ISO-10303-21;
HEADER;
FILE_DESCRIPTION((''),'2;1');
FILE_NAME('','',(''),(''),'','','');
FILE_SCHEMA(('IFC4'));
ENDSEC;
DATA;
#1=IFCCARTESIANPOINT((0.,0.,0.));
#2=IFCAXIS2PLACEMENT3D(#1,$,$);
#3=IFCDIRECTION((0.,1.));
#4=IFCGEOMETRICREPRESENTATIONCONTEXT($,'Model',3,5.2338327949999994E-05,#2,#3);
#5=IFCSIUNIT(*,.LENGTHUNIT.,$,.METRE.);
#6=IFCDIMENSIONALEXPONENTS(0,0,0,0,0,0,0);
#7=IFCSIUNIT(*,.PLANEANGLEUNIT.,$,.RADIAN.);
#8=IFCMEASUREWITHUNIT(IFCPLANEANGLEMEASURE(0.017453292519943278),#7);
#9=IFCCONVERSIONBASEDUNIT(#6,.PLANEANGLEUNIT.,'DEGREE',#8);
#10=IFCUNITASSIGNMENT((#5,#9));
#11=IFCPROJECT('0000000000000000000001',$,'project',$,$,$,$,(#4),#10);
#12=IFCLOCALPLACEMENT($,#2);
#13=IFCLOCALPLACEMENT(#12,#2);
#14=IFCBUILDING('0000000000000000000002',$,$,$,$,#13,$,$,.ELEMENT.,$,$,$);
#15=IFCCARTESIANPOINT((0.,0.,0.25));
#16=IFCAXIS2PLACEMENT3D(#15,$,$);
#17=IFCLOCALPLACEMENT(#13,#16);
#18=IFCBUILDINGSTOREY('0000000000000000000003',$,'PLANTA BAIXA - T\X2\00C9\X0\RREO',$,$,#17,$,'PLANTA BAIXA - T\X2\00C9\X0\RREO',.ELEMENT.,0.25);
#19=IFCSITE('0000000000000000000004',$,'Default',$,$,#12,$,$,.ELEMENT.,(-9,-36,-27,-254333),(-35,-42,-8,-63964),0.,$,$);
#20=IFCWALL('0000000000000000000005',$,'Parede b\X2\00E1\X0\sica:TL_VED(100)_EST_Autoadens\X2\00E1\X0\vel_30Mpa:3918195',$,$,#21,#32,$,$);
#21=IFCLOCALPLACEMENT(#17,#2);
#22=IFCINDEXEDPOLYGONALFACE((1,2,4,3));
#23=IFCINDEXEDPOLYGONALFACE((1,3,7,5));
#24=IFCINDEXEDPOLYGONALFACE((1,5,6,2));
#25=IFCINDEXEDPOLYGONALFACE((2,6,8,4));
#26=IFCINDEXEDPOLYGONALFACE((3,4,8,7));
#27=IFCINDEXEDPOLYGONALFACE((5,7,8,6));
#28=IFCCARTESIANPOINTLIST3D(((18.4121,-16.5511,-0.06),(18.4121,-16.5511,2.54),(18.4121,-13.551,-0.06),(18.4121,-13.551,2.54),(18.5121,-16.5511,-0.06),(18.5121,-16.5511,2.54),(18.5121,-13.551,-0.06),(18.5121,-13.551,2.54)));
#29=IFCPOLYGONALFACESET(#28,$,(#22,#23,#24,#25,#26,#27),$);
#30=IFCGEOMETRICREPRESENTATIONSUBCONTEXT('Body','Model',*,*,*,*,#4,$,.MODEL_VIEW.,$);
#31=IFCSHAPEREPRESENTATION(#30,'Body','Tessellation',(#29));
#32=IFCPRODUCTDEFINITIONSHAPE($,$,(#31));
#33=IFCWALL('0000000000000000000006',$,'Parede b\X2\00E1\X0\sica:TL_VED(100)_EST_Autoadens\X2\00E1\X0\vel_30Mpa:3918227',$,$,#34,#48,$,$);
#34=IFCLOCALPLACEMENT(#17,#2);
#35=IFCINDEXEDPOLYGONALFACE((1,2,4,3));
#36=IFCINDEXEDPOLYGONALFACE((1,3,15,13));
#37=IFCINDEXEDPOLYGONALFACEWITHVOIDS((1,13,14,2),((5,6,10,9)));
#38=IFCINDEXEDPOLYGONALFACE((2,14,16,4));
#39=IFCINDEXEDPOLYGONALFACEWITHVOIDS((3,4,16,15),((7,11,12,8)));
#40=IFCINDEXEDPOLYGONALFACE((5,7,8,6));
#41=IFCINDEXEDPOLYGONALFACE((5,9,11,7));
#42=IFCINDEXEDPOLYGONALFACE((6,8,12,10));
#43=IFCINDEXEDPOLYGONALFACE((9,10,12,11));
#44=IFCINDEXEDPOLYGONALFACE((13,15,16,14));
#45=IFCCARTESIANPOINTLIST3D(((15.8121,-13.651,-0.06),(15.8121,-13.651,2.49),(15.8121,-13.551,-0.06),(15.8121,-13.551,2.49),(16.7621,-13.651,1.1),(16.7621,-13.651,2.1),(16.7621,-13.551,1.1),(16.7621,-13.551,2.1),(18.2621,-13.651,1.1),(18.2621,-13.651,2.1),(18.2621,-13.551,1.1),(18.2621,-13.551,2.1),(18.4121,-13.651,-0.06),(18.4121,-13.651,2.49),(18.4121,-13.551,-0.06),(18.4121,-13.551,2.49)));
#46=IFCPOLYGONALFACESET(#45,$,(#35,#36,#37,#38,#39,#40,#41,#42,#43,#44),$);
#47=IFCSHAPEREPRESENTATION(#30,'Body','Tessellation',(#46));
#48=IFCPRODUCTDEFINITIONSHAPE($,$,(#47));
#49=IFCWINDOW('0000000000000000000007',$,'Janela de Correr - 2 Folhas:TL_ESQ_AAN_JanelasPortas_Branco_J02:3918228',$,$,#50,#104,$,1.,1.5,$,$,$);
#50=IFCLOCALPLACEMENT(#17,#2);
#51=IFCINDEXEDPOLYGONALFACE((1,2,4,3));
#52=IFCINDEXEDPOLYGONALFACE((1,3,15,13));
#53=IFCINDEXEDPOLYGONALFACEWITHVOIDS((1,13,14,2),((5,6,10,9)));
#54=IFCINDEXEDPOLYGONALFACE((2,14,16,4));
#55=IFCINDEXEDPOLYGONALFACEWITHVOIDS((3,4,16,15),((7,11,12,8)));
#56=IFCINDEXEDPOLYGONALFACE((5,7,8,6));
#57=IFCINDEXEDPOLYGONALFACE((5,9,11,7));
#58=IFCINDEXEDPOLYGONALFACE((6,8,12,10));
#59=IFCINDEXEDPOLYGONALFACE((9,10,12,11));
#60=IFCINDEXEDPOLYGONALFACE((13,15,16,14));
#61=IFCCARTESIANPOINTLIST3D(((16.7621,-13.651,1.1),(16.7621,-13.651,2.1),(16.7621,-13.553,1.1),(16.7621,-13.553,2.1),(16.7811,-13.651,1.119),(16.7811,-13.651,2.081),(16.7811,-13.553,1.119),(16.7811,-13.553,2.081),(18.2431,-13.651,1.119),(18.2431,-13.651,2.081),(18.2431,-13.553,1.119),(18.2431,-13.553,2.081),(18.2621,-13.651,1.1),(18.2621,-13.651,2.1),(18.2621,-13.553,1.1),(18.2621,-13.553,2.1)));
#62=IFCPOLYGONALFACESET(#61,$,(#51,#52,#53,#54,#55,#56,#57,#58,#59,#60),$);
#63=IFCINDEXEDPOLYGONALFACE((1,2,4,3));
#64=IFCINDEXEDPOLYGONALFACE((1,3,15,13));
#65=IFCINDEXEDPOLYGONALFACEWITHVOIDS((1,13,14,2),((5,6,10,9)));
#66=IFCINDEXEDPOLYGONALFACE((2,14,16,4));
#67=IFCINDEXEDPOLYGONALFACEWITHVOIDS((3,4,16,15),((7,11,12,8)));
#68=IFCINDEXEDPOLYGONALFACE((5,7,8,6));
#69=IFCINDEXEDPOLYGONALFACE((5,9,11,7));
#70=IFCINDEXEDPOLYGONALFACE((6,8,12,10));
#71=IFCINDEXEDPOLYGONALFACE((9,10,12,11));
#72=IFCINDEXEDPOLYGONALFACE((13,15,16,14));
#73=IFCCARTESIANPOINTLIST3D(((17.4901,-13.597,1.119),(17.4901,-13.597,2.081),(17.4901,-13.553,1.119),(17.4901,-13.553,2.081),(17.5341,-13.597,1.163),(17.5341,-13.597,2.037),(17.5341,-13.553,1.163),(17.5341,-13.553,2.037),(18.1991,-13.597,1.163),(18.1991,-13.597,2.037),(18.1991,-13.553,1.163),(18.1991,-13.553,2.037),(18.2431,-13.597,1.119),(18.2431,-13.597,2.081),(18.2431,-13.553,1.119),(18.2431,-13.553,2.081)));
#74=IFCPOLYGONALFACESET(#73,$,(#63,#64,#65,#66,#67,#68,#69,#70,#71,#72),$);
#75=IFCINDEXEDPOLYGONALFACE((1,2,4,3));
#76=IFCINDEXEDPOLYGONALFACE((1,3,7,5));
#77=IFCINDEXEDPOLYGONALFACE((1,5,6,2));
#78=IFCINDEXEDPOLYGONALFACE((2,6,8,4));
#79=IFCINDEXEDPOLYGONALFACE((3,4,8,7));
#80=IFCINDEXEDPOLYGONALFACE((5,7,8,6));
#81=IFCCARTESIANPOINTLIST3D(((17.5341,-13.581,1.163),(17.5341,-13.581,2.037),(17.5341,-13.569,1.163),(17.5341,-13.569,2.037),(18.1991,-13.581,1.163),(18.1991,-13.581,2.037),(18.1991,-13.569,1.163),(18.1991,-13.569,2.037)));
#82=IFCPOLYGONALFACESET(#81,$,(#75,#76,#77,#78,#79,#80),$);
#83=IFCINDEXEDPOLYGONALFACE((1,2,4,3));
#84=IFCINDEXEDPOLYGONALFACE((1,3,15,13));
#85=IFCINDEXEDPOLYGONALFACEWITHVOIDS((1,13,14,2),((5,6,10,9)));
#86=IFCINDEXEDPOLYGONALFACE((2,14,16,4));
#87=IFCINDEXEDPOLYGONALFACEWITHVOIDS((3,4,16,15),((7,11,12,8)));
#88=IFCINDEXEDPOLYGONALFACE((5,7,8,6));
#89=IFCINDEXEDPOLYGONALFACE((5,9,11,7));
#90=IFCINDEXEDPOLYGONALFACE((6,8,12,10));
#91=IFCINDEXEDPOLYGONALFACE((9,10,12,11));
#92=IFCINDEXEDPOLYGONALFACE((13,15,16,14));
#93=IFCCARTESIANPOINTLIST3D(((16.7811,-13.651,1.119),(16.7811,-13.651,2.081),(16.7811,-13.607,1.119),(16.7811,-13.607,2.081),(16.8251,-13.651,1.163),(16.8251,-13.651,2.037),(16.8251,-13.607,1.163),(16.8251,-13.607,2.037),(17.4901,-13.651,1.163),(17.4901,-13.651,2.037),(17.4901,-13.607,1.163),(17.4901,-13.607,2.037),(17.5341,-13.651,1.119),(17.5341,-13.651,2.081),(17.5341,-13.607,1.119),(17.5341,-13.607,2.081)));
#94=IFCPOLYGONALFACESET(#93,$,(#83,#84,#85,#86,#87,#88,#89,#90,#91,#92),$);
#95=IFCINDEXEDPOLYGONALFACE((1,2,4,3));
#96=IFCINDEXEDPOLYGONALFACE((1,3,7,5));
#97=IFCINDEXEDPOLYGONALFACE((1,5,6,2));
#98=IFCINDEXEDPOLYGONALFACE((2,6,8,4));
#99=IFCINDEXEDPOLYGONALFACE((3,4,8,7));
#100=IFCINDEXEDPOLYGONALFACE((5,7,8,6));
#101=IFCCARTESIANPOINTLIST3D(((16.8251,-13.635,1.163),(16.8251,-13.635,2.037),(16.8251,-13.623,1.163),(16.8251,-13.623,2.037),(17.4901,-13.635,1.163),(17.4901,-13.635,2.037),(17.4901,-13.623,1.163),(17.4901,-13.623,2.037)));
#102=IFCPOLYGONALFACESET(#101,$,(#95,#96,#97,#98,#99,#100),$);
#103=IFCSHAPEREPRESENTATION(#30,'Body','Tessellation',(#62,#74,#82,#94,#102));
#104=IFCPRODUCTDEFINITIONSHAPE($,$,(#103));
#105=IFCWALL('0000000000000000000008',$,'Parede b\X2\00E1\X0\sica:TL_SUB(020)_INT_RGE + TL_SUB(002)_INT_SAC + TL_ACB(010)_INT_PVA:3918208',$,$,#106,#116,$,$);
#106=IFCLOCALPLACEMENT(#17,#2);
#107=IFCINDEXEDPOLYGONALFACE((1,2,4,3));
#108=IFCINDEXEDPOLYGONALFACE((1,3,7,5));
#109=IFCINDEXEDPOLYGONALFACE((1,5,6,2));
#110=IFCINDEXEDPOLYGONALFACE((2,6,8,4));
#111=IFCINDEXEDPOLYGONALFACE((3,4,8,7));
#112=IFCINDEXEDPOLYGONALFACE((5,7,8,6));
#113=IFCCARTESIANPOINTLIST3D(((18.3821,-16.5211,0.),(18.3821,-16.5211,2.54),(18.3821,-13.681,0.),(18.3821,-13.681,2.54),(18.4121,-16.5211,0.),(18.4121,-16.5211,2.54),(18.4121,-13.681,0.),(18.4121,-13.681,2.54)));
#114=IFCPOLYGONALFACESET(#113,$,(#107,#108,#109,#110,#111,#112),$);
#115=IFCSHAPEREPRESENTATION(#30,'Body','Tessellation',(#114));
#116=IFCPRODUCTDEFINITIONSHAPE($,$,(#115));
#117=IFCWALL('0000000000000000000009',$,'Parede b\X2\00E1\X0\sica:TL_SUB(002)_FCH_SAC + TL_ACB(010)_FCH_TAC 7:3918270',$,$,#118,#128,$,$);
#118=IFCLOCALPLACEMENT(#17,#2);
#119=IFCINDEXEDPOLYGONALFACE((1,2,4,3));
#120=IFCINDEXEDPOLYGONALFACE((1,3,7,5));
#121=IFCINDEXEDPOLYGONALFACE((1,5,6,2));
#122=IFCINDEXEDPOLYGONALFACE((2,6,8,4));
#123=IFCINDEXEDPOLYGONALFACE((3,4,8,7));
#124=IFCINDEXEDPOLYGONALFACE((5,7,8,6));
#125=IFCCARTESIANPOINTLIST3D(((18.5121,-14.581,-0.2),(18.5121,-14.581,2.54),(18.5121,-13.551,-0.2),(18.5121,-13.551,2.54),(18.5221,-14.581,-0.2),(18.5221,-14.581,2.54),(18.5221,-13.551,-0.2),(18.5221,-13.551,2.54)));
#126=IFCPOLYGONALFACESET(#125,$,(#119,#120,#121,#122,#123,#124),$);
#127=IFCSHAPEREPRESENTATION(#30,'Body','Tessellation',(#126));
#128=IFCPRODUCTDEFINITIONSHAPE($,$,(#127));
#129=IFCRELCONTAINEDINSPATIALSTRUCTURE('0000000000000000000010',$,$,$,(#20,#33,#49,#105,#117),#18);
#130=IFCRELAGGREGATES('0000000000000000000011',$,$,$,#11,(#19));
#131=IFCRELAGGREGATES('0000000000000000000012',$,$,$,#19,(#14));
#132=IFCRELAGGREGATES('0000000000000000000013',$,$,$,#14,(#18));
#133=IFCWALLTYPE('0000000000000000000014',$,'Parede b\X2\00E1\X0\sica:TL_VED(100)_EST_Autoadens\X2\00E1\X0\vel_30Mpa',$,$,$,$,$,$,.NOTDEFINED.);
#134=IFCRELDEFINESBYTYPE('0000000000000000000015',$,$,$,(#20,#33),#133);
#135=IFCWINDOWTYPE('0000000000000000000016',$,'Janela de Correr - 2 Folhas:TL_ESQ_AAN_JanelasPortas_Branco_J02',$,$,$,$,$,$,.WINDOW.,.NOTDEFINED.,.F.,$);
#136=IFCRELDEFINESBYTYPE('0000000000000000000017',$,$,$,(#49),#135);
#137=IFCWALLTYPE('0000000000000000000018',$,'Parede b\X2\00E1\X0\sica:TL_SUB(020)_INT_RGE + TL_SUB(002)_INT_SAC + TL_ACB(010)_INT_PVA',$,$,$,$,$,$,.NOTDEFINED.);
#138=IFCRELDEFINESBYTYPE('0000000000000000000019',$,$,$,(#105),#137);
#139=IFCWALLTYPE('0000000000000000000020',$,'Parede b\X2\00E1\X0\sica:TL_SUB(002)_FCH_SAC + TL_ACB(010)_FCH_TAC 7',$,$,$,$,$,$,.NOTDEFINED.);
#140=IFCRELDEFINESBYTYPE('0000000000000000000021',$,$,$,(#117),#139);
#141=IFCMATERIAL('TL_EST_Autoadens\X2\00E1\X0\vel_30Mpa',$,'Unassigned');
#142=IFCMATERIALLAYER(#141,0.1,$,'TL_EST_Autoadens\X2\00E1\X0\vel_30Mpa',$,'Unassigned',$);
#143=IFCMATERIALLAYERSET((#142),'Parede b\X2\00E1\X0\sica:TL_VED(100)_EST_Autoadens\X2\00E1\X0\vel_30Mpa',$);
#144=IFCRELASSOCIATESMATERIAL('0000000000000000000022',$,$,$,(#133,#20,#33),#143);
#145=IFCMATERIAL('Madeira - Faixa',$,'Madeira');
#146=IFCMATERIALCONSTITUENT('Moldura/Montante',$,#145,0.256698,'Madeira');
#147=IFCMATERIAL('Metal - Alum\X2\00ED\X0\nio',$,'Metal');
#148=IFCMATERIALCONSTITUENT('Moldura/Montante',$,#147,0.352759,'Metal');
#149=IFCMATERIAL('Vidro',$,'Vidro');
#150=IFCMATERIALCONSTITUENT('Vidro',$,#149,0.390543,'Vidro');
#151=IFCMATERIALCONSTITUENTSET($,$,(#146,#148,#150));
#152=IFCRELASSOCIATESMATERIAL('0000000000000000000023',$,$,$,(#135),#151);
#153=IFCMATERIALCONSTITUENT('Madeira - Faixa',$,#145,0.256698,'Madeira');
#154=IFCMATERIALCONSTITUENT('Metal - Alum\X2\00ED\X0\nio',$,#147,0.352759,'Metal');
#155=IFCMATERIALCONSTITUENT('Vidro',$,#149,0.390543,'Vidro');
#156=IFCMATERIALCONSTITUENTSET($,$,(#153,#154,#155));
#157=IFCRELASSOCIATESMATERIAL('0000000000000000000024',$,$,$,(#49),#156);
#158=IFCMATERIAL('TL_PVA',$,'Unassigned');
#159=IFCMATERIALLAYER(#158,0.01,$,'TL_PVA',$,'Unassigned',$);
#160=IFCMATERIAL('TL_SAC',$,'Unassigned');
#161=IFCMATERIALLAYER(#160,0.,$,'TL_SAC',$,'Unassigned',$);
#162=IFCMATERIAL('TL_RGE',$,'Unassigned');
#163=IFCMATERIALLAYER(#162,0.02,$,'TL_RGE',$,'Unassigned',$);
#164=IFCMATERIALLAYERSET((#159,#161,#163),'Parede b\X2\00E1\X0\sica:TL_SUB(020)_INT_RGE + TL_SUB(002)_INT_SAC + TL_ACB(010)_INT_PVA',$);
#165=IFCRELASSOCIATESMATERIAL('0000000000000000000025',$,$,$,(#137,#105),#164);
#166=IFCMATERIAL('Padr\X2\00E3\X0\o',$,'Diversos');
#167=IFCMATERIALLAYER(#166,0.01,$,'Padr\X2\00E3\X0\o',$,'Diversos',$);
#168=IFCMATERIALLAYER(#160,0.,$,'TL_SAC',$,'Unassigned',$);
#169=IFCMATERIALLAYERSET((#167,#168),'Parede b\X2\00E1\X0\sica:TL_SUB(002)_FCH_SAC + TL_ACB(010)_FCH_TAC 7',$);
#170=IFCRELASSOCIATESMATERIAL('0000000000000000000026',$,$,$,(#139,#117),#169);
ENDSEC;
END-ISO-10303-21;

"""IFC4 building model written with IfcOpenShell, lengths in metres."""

from ifc_helpers import new_model, entity, si_unit, converted_unit, direction, frame, frame_2d, origin, origin_2d_with_axis, place, context, subcontext, project, spatial, polyline, rectangle, outline, extrude, source, transform, mapped, material, layer, layer_set, layer_usage, constituent, constituent_set, type_object, type_shapes, element, fill, save


model = new_model("IFC4")

# Units and contexts
model_context = context("Model", 3, precision=5.2338327949999994e-05, world=origin(), true_north=direction((0.0, 1.0)))
body_context = subcontext(model_context, "Body", "Model", "MODEL_VIEW")
ifc_project = project(units=[si_unit("LENGTHUNIT", "METRE"), converted_unit("PLANEANGLEUNIT", "DEGREE", entity("IfcPlaneAngleMeasure", 0.017453292519943278), si_unit("PLANEANGLEUNIT", "RADIAN"), dimensions=[0, 0, 0, 0, 0, 0, 0])], contexts=[model_context])

# Site, building, storey
site_placement = place(None, frame((0.0, 0.0, 0.0)))
site = spatial("IfcSite", under=ifc_project, at=site_placement, Name="Default", CompositionType="ELEMENT", RefLatitude=(-9, -36, -27, -254333), RefLongitude=(-35, -42, -8, -63964), RefElevation=0.0)
building_placement = place(site_placement, origin())
building = spatial("IfcBuilding", under=site, at=building_placement, CompositionType="ELEMENT")
storey_placement = place(building_placement, frame((0.0, 0.0, 0.25)))
storey = spatial("IfcBuildingStorey", under=building, at=storey_placement, Name="PLANTA BAIXA - TÉRREO", LongName="PLANTA BAIXA - TÉRREO", CompositionType="ELEMENT", Elevation=0.25)

# Wall
ifc_material_1 = material(Name="TL_EST_Autoadensável_30Mpa", Category="Unassigned")
ifc_layer_1 = layer(ifc_material_1, 0.1, Name="TL_EST_Autoadensável_30Mpa", Category="Unassigned")
ifc_layer_set_1 = layer_set([ifc_layer_1], Name="Parede básica:TL_VED(100)_EST_Autoadensável_30Mpa")
ifc_layer_usage_1 = layer_usage(ifc_layer_set_1, "AXIS2", "POSITIVE", -0.05)
wall_type_1 = type_object("IfcWallType", Name="Parede básica:TL_VED(100)_EST_Autoadensável_30Mpa", PredefinedType="NOTDEFINED", material=ifc_layer_set_1)
wall_1_placement = place(storey_placement, frame((18.4621, -13.551, -0.06), z_axis=(0.0, 0.0, 1.0), x_axis=(0.0, -1.0, 0.0)))
element("IfcWall", 1, at=wall_1_placement, inside=storey, type_object=wall_type_1, material=ifc_layer_usage_1, Name="Parede básica:TL_VED(100)_EST_Autoadensável_30Mpa:3918195", context=body_context, shape_type="SweptSolid", body=[
    extrude(rectangle(XDim=3.0001, YDim=0.1, at=frame_2d((1.5001, 0.0), x_axis=(-1.0, 0.0))), origin(), (0.0, 0.0, 1.0), 2.6),
])

# Wall, opening, window
ifc_layer_usage_2 = layer_usage(ifc_layer_set_1, "AXIS2", "POSITIVE", -0.05)
wall_2_placement = place(storey_placement, frame((18.4121, -13.601, -0.06), z_axis=(0.0, 0.0, 1.0), x_axis=(-1.0, 0.0, 0.0)))
wall_2 = element("IfcWall", 2, at=wall_2_placement, inside=storey, type_object=wall_type_1, material=ifc_layer_usage_2, Name="Parede básica:TL_VED(100)_EST_Autoadensável_30Mpa:3918227", context=body_context, shape_type="SweptSolid", body=[
    extrude(rectangle(XDim=2.6, YDim=0.1, at=frame_2d((1.3, 0.0), x_axis=(-1.0, 0.0))), origin(), (0.0, 0.0, 1.0), 2.55),
])
opening_placement = place(wall_2_placement, frame((1.65, 0.05, 1.16)))
opening = element("IfcOpeningElement", 3, at=opening_placement, cuts=wall_2, PredefinedType="OPENING", context=body_context, shape_type="SweptSolid", body=[
    extrude(rectangle(XDim=1.0, YDim=1.5, at=frame_2d((0.5, 0.75), x_axis=(-1.0, 0.0))), frame((0.0, 0.0, 0.0), z_axis=(0.0, -1.0, 0.0), x_axis=(0.0, 0.0, 1.0)), (0.0, 0.0, 1.0), 0.1),
])
ifc_material_2 = material(Name="Madeira - Faixa", Category="Madeira")
ifc_constituent_1 = constituent(ifc_material_2, Name="Madeira - Faixa", Category="Madeira", fraction=0.256698)
ifc_material_3 = material(Name="Metal - Alumínio", Category="Metal")
ifc_constituent_2 = constituent(ifc_material_3, Name="Metal - Alumínio", Category="Metal", fraction=0.352759)
ifc_material_4 = material(Name="Vidro", Category="Vidro")
ifc_constituent_3 = constituent(ifc_material_4, Name="Vidro", Category="Vidro", fraction=0.390543)
ifc_constituent_set_1 = constituent_set(constituents=[ifc_constituent_1, ifc_constituent_2, ifc_constituent_3])
ifc_constituent_4 = constituent(ifc_material_2, Name="Moldura/Montante", Category="Madeira", fraction=0.256698)
ifc_constituent_5 = constituent(ifc_material_3, Name="Moldura/Montante", Category="Metal", fraction=0.352759)
ifc_constituent_6 = constituent(ifc_material_4, Name="Vidro", Category="Vidro", fraction=0.390543)
ifc_constituent_set_2 = constituent_set(constituents=[ifc_constituent_4, ifc_constituent_5, ifc_constituent_6])
window_type = type_object("IfcWindowType", Name="Janela de Correr - 2 Folhas:TL_ESQ_AAN_JanelasPortas_Branco_J02", ParameterTakesPrecedence=False, PartitioningType="NOTDEFINED", PredefinedType="WINDOW", material=ifc_constituent_set_2)
shared_shape_1 = source(origin(), body_context, "Body", "SweptSolid", [
    extrude(outline(polyline([(-0.75, -0.5), (0.75, -0.5), (0.75, 0.5), (-0.75, 0.5), (-0.75, -0.5)]), holes=[polyline([(-0.731, -0.481), (-0.731, 0.481), (0.731, 0.481), (0.731, -0.481), (-0.731, -0.481)])]), frame((0.75, 0.0, 0.5), z_axis=(0.0, 1.0, 0.0), x_axis=(1.0, 0.0, 0.0)), (0.0, 0.0, 1.0), 0.098),
    extrude(outline(polyline([(-0.3765, -0.481), (0.3765, -0.481), (0.3765, 0.481), (-0.3765, 0.481), (-0.3765, -0.481)]), holes=[polyline([(-0.3325, -0.437), (-0.3325, 0.437), (0.3325, 0.437), (0.3325, -0.437), (-0.3325, -0.437)])]), frame((1.1045, 0.054, 0.5), z_axis=(0.0, 1.0, 0.0), x_axis=(1.0, 0.0, 0.0)), (0.0, 0.0, 1.0), 0.044),
    extrude(rectangle(XDim=0.012, YDim=0.665, at=origin_2d_with_axis()), frame((1.1045, 0.076, 0.063), z_axis=(0.0, 0.0, 1.0), x_axis=(0.0, -1.0, 0.0)), (0.0, 0.0, 1.0), 0.874),
    extrude(outline(polyline([(-0.481, -0.3765), (0.481, -0.3765), (0.481, 0.3765), (-0.481, 0.3765), (-0.481, -0.3765)]), holes=[polyline([(-0.437, -0.3325), (-0.437, 0.3325), (0.437, 0.3325), (0.437, -0.3325), (-0.437, -0.3325)])]), frame((0.3955, 0.0, 0.5), z_axis=(0.0, 1.0, 0.0), x_axis=(0.0, 0.0, -1.0)), (0.0, 0.0, 1.0), 0.044),
    extrude(rectangle(XDim=0.012, YDim=0.665, at=origin_2d_with_axis()), frame((0.3955, 0.022, 0.063), z_axis=(0.0, 0.0, 1.0), x_axis=(0.0, -1.0, 0.0)), (0.0, 0.0, 1.0), 0.874),
])
type_shapes(window_type, [shared_shape_1])
window_placement = place(opening_placement, frame((0.0, 0.0, 0.0), z_axis=(0.0, 0.0, 1.0), x_axis=(-1.0, 0.0, 0.0)))
window = element("IfcWindow", 4, at=window_placement, inside=storey, type_object=window_type, material=ifc_constituent_set_1, Name="Janela de Correr - 2 Folhas:TL_ESQ_AAN_JanelasPortas_Branco_J02:3918228", OverallHeight=1.0, OverallWidth=1.5, context=body_context, shape_type="MappedRepresentation", body=[
    mapped(shared_shape_1, transform((0.0, 0.0, 0.0), scale=1.0)),
])
fill(opening, window)

# Walls
ifc_material_5 = material(Name="TL_PVA", Category="Unassigned")
ifc_layer_2 = layer(ifc_material_5, 0.01, Name="TL_PVA", Category="Unassigned")
ifc_material_6 = material(Name="TL_SAC", Category="Unassigned")
ifc_layer_3 = layer(ifc_material_6, 0.0, Name="TL_SAC", Category="Unassigned")
ifc_material_7 = material(Name="TL_RGE", Category="Unassigned")
ifc_layer_4 = layer(ifc_material_7, 0.02, Name="TL_RGE", Category="Unassigned")
ifc_layer_set_2 = layer_set([ifc_layer_2, ifc_layer_3, ifc_layer_4], Name="Parede básica:TL_SUB(020)_INT_RGE + TL_SUB(002)_INT_SAC + TL_ACB(010)_INT_PVA")
ifc_layer_usage_3 = layer_usage(ifc_layer_set_2, "AXIS2", "POSITIVE", -0.015)
wall_type_2 = type_object("IfcWallType", Name="Parede básica:TL_SUB(020)_INT_RGE + TL_SUB(002)_INT_SAC + TL_ACB(010)_INT_PVA", PredefinedType="NOTDEFINED", material=ifc_layer_set_2)
wall_3_placement = place(storey_placement, frame((18.3971, -13.681, 0.0), z_axis=(0.0, 0.0, 1.0), x_axis=(0.0, -1.0, 0.0)))
element("IfcWall", 5, at=wall_3_placement, inside=storey, type_object=wall_type_2, material=ifc_layer_usage_3, Name="Parede básica:TL_SUB(020)_INT_RGE + TL_SUB(002)_INT_SAC + TL_ACB(010)_INT_PVA:3918208", context=body_context, shape_type="SweptSolid", body=[
    extrude(rectangle(XDim=2.8401, YDim=0.03, at=frame_2d((1.4201, 0.0), x_axis=(-1.0, 0.0))), origin(), (0.0, 0.0, 1.0), 2.54),
])
ifc_material_8 = material(Name="Padrão", Category="Diversos")
ifc_layer_5 = layer(ifc_material_8, 0.01, Name="Padrão", Category="Diversos")
ifc_layer_6 = layer(ifc_material_6, 0.0, Name="TL_SAC", Category="Unassigned")
ifc_layer_set_3 = layer_set([ifc_layer_5, ifc_layer_6], Name="Parede básica:TL_SUB(002)_FCH_SAC + TL_ACB(010)_FCH_TAC 7")
ifc_layer_usage_4 = layer_usage(ifc_layer_set_3, "AXIS2", "POSITIVE", -0.005)
wall_type_3 = type_object("IfcWallType", Name="Parede básica:TL_SUB(002)_FCH_SAC + TL_ACB(010)_FCH_TAC 7", PredefinedType="NOTDEFINED", material=ifc_layer_set_3)
wall_4_placement = place(storey_placement, frame((18.5171, -13.551, -0.2), z_axis=(0.0, 0.0, 1.0), x_axis=(0.0, -1.0, 0.0)))
element("IfcWall", 6, at=wall_4_placement, inside=storey, type_object=wall_type_3, material=ifc_layer_usage_4, Name="Parede básica:TL_SUB(002)_FCH_SAC + TL_ACB(010)_FCH_TAC 7:3918270", context=body_context, shape_type="SweptSolid", body=[
    extrude(rectangle(XDim=1.03, YDim=0.01, at=frame_2d((0.515, 0.0), x_axis=(-1.0, 0.0))), origin(), (0.0, 0.0, 1.0), 2.74),
])

save(model, "model.ifc")
